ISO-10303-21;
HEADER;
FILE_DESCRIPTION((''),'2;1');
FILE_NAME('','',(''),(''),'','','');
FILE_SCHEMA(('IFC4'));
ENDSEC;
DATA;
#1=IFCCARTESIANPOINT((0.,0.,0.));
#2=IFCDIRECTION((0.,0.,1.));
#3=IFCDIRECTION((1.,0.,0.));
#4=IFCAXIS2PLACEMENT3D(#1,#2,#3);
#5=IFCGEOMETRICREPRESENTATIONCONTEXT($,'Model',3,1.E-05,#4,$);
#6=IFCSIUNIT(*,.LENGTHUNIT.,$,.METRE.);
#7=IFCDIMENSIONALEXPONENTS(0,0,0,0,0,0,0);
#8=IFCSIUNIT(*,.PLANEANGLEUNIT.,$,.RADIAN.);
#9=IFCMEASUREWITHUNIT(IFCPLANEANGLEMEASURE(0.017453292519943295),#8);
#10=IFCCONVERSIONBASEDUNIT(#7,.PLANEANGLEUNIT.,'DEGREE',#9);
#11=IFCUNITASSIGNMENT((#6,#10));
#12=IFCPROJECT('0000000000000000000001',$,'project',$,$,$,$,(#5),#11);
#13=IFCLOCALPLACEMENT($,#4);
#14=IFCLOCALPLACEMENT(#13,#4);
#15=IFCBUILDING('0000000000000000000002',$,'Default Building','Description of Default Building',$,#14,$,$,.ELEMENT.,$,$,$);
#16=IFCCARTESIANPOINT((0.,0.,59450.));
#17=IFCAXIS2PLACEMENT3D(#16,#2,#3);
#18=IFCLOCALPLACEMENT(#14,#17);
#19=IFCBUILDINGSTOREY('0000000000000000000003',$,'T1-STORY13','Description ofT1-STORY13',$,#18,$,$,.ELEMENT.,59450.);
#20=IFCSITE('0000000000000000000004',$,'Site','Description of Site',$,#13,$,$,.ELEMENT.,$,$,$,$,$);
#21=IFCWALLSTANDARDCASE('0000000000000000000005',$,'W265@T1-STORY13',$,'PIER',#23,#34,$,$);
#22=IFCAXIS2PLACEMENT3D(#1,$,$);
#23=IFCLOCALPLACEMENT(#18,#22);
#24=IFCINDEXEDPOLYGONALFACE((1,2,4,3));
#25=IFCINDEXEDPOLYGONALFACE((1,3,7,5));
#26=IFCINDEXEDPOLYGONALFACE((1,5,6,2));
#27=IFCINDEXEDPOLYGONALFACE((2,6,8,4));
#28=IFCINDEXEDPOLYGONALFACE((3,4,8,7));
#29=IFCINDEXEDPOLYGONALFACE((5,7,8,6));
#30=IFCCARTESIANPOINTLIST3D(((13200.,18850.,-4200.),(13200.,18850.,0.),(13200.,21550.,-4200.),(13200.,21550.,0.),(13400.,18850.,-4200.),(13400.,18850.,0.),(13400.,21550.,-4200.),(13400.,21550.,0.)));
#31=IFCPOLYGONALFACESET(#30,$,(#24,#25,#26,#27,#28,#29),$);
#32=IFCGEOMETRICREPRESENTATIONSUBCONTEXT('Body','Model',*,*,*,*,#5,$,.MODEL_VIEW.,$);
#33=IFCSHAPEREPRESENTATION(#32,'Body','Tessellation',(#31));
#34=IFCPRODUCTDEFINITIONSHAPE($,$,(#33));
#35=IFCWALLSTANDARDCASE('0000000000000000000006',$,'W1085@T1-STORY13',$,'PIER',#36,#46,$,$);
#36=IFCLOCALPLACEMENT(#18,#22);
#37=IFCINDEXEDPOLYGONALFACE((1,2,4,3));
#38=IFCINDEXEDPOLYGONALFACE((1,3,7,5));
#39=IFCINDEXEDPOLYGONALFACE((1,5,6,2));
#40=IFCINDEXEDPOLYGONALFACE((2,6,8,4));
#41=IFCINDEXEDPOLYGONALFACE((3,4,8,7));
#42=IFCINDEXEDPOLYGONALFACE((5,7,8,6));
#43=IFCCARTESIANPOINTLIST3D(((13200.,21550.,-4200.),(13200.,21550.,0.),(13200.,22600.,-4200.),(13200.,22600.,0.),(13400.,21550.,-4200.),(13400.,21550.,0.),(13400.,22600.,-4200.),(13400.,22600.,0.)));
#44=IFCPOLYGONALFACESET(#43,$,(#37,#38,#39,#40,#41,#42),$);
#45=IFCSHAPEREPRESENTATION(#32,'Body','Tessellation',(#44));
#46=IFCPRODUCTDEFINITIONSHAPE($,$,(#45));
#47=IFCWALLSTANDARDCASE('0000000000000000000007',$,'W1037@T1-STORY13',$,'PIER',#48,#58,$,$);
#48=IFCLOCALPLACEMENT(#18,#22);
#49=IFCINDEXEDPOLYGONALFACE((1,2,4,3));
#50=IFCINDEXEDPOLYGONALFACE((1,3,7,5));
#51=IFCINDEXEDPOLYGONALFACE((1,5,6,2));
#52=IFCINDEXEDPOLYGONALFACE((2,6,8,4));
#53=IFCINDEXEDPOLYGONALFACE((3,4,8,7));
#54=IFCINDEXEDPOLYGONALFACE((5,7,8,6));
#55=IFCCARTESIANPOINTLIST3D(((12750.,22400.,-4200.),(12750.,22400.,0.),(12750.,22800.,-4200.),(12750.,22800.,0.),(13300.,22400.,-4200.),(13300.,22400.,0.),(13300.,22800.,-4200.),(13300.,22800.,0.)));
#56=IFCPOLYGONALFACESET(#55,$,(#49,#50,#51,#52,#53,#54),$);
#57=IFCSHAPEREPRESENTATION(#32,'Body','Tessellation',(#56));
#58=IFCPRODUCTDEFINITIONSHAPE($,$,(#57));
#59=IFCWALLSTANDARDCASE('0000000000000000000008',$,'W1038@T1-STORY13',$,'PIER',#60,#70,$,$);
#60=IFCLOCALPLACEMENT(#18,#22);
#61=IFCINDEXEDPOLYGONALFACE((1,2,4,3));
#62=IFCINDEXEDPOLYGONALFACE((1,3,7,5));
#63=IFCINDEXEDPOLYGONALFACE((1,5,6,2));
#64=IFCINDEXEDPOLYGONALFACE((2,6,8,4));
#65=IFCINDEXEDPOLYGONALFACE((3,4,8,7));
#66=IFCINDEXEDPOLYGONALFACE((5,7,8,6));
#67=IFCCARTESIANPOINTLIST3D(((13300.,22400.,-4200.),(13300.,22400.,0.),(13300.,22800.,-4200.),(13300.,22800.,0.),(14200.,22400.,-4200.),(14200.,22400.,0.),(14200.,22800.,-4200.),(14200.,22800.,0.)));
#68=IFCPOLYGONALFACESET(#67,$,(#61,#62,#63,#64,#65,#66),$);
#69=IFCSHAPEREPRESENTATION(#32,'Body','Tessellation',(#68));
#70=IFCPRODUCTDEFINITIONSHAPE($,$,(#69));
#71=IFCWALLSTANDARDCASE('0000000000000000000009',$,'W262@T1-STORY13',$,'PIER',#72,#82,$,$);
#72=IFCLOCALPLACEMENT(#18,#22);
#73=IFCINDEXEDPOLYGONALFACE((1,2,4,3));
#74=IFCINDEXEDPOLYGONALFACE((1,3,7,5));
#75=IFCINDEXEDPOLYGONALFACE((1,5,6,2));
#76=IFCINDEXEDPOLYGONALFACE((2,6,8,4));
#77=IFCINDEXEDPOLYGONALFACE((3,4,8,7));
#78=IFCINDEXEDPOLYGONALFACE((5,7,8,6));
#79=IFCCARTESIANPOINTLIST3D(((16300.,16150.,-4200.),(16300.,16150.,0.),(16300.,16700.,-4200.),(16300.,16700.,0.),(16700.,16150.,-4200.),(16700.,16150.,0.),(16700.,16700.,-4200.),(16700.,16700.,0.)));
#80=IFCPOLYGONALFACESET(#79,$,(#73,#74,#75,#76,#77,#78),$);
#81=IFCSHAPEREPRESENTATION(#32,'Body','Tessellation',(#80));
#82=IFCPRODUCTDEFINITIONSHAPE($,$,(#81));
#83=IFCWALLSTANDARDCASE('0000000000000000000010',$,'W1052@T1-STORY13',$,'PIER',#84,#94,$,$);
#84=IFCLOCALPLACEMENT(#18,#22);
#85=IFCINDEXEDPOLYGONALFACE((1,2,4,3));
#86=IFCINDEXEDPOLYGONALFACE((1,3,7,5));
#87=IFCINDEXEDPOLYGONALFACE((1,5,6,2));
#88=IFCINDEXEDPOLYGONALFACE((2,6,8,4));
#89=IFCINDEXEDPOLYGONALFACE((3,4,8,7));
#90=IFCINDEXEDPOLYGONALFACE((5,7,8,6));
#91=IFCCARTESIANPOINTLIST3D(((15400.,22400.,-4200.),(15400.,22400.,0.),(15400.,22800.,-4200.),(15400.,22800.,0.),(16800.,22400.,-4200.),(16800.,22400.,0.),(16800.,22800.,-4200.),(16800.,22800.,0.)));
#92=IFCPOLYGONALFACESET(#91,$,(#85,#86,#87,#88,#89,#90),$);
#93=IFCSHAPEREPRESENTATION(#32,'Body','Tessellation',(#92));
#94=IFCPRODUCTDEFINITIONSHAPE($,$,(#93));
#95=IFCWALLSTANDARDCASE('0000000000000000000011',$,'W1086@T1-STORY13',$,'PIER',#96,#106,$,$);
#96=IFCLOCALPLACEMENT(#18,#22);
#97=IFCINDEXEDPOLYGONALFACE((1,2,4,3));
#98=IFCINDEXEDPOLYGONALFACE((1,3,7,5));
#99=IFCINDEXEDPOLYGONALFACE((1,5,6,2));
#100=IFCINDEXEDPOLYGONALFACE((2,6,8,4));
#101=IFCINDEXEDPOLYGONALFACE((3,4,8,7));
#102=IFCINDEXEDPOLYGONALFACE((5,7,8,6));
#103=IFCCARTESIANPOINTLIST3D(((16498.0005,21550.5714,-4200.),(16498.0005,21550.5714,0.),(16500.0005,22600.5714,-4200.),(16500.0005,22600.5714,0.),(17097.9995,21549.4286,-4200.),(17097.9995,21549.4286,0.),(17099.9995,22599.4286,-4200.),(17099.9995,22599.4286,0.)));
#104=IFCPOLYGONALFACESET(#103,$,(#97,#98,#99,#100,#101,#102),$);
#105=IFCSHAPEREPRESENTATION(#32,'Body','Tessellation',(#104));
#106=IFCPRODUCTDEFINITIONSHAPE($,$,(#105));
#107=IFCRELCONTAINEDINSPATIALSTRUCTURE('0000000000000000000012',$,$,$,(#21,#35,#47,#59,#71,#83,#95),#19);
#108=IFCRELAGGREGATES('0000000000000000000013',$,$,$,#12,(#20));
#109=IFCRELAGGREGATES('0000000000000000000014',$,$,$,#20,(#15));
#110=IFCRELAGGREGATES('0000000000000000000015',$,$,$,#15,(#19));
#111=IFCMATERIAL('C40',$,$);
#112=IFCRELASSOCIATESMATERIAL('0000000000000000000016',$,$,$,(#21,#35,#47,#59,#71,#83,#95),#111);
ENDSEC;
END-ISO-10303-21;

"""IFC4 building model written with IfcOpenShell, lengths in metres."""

from ifc_helpers import new_model, entity, si_unit, converted_unit, frame, origin_with_axes, place, context, subcontext, project, spatial, indexed_curve, outline, extrude, material, element, save


model = new_model("IFC4")

# Units and contexts
model_context = context("Model", 3, precision=1e-05, world=origin_with_axes())
body_context = subcontext(model_context, "Body", "Model", "MODEL_VIEW")
ifc_project = project(units=[si_unit("LENGTHUNIT", "METRE"), converted_unit("PLANEANGLEUNIT", "DEGREE", entity("IfcPlaneAngleMeasure", 0.017453292519943295), si_unit("PLANEANGLEUNIT", "RADIAN"), dimensions=[0, 0, 0, 0, 0, 0, 0])], contexts=[model_context])

# Site, building, storey
site_placement = place(None, origin_with_axes())
site = spatial("IfcSite", under=ifc_project, at=site_placement, Name="Site", Description="Description of Site", CompositionType="ELEMENT")
building_placement = place(site_placement, origin_with_axes())
building = spatial("IfcBuilding", under=site, at=building_placement, Name="Default Building", Description="Description of Default Building", CompositionType="ELEMENT")
storey_placement = place(building_placement, frame((0.0, 0.0, 59450.0), z_axis=(0.0, 0.0, 1.0), x_axis=(1.0, 0.0, 0.0)))
storey = spatial("IfcBuildingStorey", under=building, at=storey_placement, Name="T1-STORY13", Description="Description ofT1-STORY13", CompositionType="ELEMENT", Elevation=59450.0)

# Walls
ifc_material_1 = material(Name="C40")
wall_1_placement = place(storey_placement, frame((13300.0, 18850.0, -4200.0), z_axis=(0.0, 0.0, 1.0), x_axis=(0.0, 1.0, 0.0)))
element("IfcWallStandardCase", 1, at=wall_1_placement, inside=storey, material=ifc_material_1, Name="W265@T1-STORY13", ObjectType="PIER", context=body_context, shape_type="SweptSolid", body=[
    extrude(outline(indexed_curve([(0.0, -100.0), (0.0, 100.0), (2700.0, 100.0), (2700.0, -100.0), (0.0, -100.0)], self_intersect=False)), origin_with_axes(), (0.0, 0.0, 1.0), 4200.0),
])
wall_2_placement = place(storey_placement, frame((13300.0, 21550.0, -4200.0), z_axis=(0.0, 0.0, 1.0), x_axis=(0.0, 1.0, 0.0)))
element("IfcWallStandardCase", 2, at=wall_2_placement, inside=storey, material=ifc_material_1, Name="W1085@T1-STORY13", ObjectType="PIER", context=body_context, shape_type="SweptSolid", body=[
    extrude(outline(indexed_curve([(0.0, -100.0), (0.0, 100.0), (1050.0, 100.0), (1050.0, -100.0), (0.0, -100.0)], self_intersect=False)), origin_with_axes(), (0.0, 0.0, 1.0), 4200.0),
])
wall_3_placement = place(storey_placement, frame((12750.0, 22600.0, -4200.0), z_axis=(0.0, 0.0, 1.0), x_axis=(1.0, 0.0, 0.0)))
element("IfcWallStandardCase", 3, at=wall_3_placement, inside=storey, material=ifc_material_1, Name="W1037@T1-STORY13", ObjectType="PIER", context=body_context, shape_type="SweptSolid", body=[
    extrude(outline(indexed_curve([(0.0, -200.0), (0.0, 200.0), (550.0, 200.0), (550.0, -200.0), (0.0, -200.0)], self_intersect=False)), origin_with_axes(), (0.0, 0.0, 1.0), 4200.0),
])
wall_4_placement = place(storey_placement, frame((13300.0, 22600.0, -4200.0), z_axis=(0.0, 0.0, 1.0), x_axis=(1.0, 0.0, 0.0)))
element("IfcWallStandardCase", 4, at=wall_4_placement, inside=storey, material=ifc_material_1, Name="W1038@T1-STORY13", ObjectType="PIER", context=body_context, shape_type="SweptSolid", body=[
    extrude(outline(indexed_curve([(0.0, -200.0), (0.0, 200.0), (900.0, 200.0), (900.0, -200.0), (0.0, -200.0)], self_intersect=False)), origin_with_axes(), (0.0, 0.0, 1.0), 4200.0),
])
wall_5_placement = place(storey_placement, frame((16500.0, 16150.0, -4200.0), z_axis=(0.0, 0.0, 1.0), x_axis=(0.0, 1.0, 0.0)))
element("IfcWallStandardCase", 5, at=wall_5_placement, inside=storey, material=ifc_material_1, Name="W262@T1-STORY13", ObjectType="PIER", context=body_context, shape_type="SweptSolid", body=[
    extrude(outline(indexed_curve([(0.0, -200.0), (0.0, 200.0), (550.0, 200.0), (550.0, -200.0), (0.0, -200.0)], self_intersect=False)), origin_with_axes(), (0.0, 0.0, 1.0), 4200.0),
])
wall_6_placement = place(storey_placement, frame((15400.0, 22600.0, -4200.0), z_axis=(0.0, 0.0, 1.0), x_axis=(1.0, 0.0, 0.0)))
element("IfcWallStandardCase", 6, at=wall_6_placement, inside=storey, material=ifc_material_1, Name="W1052@T1-STORY13", ObjectType="PIER", context=body_context, shape_type="SweptSolid", body=[
    extrude(outline(indexed_curve([(0.0, -200.0), (0.0, 200.0), (1400.0, 200.0), (1400.0, -200.0), (0.0, -200.0)], self_intersect=False)), origin_with_axes(), (0.0, 0.0, 1.0), 4200.0),
])
wall_7_placement = place(storey_placement, frame((16798.0, 21550.0, -4200.0), z_axis=(0.0, 0.0, 1.0), x_axis=(0.001905, 0.999998, 0.0)))
element("IfcWallStandardCase", 7, at=wall_7_placement, inside=storey, material=ifc_material_1, Name="W1086@T1-STORY13", ObjectType="PIER", context=body_context, shape_type="SweptSolid", body=[
    extrude(outline(indexed_curve([(0.0, -300.0), (0.0, 300.0), (1050.0019, 300.0), (1050.0019, -300.0), (0.0, -300.0)], self_intersect=False)), origin_with_axes(), (0.0, 0.0, 1.0), 4200.0),
])

save(model, "model.ifc")
